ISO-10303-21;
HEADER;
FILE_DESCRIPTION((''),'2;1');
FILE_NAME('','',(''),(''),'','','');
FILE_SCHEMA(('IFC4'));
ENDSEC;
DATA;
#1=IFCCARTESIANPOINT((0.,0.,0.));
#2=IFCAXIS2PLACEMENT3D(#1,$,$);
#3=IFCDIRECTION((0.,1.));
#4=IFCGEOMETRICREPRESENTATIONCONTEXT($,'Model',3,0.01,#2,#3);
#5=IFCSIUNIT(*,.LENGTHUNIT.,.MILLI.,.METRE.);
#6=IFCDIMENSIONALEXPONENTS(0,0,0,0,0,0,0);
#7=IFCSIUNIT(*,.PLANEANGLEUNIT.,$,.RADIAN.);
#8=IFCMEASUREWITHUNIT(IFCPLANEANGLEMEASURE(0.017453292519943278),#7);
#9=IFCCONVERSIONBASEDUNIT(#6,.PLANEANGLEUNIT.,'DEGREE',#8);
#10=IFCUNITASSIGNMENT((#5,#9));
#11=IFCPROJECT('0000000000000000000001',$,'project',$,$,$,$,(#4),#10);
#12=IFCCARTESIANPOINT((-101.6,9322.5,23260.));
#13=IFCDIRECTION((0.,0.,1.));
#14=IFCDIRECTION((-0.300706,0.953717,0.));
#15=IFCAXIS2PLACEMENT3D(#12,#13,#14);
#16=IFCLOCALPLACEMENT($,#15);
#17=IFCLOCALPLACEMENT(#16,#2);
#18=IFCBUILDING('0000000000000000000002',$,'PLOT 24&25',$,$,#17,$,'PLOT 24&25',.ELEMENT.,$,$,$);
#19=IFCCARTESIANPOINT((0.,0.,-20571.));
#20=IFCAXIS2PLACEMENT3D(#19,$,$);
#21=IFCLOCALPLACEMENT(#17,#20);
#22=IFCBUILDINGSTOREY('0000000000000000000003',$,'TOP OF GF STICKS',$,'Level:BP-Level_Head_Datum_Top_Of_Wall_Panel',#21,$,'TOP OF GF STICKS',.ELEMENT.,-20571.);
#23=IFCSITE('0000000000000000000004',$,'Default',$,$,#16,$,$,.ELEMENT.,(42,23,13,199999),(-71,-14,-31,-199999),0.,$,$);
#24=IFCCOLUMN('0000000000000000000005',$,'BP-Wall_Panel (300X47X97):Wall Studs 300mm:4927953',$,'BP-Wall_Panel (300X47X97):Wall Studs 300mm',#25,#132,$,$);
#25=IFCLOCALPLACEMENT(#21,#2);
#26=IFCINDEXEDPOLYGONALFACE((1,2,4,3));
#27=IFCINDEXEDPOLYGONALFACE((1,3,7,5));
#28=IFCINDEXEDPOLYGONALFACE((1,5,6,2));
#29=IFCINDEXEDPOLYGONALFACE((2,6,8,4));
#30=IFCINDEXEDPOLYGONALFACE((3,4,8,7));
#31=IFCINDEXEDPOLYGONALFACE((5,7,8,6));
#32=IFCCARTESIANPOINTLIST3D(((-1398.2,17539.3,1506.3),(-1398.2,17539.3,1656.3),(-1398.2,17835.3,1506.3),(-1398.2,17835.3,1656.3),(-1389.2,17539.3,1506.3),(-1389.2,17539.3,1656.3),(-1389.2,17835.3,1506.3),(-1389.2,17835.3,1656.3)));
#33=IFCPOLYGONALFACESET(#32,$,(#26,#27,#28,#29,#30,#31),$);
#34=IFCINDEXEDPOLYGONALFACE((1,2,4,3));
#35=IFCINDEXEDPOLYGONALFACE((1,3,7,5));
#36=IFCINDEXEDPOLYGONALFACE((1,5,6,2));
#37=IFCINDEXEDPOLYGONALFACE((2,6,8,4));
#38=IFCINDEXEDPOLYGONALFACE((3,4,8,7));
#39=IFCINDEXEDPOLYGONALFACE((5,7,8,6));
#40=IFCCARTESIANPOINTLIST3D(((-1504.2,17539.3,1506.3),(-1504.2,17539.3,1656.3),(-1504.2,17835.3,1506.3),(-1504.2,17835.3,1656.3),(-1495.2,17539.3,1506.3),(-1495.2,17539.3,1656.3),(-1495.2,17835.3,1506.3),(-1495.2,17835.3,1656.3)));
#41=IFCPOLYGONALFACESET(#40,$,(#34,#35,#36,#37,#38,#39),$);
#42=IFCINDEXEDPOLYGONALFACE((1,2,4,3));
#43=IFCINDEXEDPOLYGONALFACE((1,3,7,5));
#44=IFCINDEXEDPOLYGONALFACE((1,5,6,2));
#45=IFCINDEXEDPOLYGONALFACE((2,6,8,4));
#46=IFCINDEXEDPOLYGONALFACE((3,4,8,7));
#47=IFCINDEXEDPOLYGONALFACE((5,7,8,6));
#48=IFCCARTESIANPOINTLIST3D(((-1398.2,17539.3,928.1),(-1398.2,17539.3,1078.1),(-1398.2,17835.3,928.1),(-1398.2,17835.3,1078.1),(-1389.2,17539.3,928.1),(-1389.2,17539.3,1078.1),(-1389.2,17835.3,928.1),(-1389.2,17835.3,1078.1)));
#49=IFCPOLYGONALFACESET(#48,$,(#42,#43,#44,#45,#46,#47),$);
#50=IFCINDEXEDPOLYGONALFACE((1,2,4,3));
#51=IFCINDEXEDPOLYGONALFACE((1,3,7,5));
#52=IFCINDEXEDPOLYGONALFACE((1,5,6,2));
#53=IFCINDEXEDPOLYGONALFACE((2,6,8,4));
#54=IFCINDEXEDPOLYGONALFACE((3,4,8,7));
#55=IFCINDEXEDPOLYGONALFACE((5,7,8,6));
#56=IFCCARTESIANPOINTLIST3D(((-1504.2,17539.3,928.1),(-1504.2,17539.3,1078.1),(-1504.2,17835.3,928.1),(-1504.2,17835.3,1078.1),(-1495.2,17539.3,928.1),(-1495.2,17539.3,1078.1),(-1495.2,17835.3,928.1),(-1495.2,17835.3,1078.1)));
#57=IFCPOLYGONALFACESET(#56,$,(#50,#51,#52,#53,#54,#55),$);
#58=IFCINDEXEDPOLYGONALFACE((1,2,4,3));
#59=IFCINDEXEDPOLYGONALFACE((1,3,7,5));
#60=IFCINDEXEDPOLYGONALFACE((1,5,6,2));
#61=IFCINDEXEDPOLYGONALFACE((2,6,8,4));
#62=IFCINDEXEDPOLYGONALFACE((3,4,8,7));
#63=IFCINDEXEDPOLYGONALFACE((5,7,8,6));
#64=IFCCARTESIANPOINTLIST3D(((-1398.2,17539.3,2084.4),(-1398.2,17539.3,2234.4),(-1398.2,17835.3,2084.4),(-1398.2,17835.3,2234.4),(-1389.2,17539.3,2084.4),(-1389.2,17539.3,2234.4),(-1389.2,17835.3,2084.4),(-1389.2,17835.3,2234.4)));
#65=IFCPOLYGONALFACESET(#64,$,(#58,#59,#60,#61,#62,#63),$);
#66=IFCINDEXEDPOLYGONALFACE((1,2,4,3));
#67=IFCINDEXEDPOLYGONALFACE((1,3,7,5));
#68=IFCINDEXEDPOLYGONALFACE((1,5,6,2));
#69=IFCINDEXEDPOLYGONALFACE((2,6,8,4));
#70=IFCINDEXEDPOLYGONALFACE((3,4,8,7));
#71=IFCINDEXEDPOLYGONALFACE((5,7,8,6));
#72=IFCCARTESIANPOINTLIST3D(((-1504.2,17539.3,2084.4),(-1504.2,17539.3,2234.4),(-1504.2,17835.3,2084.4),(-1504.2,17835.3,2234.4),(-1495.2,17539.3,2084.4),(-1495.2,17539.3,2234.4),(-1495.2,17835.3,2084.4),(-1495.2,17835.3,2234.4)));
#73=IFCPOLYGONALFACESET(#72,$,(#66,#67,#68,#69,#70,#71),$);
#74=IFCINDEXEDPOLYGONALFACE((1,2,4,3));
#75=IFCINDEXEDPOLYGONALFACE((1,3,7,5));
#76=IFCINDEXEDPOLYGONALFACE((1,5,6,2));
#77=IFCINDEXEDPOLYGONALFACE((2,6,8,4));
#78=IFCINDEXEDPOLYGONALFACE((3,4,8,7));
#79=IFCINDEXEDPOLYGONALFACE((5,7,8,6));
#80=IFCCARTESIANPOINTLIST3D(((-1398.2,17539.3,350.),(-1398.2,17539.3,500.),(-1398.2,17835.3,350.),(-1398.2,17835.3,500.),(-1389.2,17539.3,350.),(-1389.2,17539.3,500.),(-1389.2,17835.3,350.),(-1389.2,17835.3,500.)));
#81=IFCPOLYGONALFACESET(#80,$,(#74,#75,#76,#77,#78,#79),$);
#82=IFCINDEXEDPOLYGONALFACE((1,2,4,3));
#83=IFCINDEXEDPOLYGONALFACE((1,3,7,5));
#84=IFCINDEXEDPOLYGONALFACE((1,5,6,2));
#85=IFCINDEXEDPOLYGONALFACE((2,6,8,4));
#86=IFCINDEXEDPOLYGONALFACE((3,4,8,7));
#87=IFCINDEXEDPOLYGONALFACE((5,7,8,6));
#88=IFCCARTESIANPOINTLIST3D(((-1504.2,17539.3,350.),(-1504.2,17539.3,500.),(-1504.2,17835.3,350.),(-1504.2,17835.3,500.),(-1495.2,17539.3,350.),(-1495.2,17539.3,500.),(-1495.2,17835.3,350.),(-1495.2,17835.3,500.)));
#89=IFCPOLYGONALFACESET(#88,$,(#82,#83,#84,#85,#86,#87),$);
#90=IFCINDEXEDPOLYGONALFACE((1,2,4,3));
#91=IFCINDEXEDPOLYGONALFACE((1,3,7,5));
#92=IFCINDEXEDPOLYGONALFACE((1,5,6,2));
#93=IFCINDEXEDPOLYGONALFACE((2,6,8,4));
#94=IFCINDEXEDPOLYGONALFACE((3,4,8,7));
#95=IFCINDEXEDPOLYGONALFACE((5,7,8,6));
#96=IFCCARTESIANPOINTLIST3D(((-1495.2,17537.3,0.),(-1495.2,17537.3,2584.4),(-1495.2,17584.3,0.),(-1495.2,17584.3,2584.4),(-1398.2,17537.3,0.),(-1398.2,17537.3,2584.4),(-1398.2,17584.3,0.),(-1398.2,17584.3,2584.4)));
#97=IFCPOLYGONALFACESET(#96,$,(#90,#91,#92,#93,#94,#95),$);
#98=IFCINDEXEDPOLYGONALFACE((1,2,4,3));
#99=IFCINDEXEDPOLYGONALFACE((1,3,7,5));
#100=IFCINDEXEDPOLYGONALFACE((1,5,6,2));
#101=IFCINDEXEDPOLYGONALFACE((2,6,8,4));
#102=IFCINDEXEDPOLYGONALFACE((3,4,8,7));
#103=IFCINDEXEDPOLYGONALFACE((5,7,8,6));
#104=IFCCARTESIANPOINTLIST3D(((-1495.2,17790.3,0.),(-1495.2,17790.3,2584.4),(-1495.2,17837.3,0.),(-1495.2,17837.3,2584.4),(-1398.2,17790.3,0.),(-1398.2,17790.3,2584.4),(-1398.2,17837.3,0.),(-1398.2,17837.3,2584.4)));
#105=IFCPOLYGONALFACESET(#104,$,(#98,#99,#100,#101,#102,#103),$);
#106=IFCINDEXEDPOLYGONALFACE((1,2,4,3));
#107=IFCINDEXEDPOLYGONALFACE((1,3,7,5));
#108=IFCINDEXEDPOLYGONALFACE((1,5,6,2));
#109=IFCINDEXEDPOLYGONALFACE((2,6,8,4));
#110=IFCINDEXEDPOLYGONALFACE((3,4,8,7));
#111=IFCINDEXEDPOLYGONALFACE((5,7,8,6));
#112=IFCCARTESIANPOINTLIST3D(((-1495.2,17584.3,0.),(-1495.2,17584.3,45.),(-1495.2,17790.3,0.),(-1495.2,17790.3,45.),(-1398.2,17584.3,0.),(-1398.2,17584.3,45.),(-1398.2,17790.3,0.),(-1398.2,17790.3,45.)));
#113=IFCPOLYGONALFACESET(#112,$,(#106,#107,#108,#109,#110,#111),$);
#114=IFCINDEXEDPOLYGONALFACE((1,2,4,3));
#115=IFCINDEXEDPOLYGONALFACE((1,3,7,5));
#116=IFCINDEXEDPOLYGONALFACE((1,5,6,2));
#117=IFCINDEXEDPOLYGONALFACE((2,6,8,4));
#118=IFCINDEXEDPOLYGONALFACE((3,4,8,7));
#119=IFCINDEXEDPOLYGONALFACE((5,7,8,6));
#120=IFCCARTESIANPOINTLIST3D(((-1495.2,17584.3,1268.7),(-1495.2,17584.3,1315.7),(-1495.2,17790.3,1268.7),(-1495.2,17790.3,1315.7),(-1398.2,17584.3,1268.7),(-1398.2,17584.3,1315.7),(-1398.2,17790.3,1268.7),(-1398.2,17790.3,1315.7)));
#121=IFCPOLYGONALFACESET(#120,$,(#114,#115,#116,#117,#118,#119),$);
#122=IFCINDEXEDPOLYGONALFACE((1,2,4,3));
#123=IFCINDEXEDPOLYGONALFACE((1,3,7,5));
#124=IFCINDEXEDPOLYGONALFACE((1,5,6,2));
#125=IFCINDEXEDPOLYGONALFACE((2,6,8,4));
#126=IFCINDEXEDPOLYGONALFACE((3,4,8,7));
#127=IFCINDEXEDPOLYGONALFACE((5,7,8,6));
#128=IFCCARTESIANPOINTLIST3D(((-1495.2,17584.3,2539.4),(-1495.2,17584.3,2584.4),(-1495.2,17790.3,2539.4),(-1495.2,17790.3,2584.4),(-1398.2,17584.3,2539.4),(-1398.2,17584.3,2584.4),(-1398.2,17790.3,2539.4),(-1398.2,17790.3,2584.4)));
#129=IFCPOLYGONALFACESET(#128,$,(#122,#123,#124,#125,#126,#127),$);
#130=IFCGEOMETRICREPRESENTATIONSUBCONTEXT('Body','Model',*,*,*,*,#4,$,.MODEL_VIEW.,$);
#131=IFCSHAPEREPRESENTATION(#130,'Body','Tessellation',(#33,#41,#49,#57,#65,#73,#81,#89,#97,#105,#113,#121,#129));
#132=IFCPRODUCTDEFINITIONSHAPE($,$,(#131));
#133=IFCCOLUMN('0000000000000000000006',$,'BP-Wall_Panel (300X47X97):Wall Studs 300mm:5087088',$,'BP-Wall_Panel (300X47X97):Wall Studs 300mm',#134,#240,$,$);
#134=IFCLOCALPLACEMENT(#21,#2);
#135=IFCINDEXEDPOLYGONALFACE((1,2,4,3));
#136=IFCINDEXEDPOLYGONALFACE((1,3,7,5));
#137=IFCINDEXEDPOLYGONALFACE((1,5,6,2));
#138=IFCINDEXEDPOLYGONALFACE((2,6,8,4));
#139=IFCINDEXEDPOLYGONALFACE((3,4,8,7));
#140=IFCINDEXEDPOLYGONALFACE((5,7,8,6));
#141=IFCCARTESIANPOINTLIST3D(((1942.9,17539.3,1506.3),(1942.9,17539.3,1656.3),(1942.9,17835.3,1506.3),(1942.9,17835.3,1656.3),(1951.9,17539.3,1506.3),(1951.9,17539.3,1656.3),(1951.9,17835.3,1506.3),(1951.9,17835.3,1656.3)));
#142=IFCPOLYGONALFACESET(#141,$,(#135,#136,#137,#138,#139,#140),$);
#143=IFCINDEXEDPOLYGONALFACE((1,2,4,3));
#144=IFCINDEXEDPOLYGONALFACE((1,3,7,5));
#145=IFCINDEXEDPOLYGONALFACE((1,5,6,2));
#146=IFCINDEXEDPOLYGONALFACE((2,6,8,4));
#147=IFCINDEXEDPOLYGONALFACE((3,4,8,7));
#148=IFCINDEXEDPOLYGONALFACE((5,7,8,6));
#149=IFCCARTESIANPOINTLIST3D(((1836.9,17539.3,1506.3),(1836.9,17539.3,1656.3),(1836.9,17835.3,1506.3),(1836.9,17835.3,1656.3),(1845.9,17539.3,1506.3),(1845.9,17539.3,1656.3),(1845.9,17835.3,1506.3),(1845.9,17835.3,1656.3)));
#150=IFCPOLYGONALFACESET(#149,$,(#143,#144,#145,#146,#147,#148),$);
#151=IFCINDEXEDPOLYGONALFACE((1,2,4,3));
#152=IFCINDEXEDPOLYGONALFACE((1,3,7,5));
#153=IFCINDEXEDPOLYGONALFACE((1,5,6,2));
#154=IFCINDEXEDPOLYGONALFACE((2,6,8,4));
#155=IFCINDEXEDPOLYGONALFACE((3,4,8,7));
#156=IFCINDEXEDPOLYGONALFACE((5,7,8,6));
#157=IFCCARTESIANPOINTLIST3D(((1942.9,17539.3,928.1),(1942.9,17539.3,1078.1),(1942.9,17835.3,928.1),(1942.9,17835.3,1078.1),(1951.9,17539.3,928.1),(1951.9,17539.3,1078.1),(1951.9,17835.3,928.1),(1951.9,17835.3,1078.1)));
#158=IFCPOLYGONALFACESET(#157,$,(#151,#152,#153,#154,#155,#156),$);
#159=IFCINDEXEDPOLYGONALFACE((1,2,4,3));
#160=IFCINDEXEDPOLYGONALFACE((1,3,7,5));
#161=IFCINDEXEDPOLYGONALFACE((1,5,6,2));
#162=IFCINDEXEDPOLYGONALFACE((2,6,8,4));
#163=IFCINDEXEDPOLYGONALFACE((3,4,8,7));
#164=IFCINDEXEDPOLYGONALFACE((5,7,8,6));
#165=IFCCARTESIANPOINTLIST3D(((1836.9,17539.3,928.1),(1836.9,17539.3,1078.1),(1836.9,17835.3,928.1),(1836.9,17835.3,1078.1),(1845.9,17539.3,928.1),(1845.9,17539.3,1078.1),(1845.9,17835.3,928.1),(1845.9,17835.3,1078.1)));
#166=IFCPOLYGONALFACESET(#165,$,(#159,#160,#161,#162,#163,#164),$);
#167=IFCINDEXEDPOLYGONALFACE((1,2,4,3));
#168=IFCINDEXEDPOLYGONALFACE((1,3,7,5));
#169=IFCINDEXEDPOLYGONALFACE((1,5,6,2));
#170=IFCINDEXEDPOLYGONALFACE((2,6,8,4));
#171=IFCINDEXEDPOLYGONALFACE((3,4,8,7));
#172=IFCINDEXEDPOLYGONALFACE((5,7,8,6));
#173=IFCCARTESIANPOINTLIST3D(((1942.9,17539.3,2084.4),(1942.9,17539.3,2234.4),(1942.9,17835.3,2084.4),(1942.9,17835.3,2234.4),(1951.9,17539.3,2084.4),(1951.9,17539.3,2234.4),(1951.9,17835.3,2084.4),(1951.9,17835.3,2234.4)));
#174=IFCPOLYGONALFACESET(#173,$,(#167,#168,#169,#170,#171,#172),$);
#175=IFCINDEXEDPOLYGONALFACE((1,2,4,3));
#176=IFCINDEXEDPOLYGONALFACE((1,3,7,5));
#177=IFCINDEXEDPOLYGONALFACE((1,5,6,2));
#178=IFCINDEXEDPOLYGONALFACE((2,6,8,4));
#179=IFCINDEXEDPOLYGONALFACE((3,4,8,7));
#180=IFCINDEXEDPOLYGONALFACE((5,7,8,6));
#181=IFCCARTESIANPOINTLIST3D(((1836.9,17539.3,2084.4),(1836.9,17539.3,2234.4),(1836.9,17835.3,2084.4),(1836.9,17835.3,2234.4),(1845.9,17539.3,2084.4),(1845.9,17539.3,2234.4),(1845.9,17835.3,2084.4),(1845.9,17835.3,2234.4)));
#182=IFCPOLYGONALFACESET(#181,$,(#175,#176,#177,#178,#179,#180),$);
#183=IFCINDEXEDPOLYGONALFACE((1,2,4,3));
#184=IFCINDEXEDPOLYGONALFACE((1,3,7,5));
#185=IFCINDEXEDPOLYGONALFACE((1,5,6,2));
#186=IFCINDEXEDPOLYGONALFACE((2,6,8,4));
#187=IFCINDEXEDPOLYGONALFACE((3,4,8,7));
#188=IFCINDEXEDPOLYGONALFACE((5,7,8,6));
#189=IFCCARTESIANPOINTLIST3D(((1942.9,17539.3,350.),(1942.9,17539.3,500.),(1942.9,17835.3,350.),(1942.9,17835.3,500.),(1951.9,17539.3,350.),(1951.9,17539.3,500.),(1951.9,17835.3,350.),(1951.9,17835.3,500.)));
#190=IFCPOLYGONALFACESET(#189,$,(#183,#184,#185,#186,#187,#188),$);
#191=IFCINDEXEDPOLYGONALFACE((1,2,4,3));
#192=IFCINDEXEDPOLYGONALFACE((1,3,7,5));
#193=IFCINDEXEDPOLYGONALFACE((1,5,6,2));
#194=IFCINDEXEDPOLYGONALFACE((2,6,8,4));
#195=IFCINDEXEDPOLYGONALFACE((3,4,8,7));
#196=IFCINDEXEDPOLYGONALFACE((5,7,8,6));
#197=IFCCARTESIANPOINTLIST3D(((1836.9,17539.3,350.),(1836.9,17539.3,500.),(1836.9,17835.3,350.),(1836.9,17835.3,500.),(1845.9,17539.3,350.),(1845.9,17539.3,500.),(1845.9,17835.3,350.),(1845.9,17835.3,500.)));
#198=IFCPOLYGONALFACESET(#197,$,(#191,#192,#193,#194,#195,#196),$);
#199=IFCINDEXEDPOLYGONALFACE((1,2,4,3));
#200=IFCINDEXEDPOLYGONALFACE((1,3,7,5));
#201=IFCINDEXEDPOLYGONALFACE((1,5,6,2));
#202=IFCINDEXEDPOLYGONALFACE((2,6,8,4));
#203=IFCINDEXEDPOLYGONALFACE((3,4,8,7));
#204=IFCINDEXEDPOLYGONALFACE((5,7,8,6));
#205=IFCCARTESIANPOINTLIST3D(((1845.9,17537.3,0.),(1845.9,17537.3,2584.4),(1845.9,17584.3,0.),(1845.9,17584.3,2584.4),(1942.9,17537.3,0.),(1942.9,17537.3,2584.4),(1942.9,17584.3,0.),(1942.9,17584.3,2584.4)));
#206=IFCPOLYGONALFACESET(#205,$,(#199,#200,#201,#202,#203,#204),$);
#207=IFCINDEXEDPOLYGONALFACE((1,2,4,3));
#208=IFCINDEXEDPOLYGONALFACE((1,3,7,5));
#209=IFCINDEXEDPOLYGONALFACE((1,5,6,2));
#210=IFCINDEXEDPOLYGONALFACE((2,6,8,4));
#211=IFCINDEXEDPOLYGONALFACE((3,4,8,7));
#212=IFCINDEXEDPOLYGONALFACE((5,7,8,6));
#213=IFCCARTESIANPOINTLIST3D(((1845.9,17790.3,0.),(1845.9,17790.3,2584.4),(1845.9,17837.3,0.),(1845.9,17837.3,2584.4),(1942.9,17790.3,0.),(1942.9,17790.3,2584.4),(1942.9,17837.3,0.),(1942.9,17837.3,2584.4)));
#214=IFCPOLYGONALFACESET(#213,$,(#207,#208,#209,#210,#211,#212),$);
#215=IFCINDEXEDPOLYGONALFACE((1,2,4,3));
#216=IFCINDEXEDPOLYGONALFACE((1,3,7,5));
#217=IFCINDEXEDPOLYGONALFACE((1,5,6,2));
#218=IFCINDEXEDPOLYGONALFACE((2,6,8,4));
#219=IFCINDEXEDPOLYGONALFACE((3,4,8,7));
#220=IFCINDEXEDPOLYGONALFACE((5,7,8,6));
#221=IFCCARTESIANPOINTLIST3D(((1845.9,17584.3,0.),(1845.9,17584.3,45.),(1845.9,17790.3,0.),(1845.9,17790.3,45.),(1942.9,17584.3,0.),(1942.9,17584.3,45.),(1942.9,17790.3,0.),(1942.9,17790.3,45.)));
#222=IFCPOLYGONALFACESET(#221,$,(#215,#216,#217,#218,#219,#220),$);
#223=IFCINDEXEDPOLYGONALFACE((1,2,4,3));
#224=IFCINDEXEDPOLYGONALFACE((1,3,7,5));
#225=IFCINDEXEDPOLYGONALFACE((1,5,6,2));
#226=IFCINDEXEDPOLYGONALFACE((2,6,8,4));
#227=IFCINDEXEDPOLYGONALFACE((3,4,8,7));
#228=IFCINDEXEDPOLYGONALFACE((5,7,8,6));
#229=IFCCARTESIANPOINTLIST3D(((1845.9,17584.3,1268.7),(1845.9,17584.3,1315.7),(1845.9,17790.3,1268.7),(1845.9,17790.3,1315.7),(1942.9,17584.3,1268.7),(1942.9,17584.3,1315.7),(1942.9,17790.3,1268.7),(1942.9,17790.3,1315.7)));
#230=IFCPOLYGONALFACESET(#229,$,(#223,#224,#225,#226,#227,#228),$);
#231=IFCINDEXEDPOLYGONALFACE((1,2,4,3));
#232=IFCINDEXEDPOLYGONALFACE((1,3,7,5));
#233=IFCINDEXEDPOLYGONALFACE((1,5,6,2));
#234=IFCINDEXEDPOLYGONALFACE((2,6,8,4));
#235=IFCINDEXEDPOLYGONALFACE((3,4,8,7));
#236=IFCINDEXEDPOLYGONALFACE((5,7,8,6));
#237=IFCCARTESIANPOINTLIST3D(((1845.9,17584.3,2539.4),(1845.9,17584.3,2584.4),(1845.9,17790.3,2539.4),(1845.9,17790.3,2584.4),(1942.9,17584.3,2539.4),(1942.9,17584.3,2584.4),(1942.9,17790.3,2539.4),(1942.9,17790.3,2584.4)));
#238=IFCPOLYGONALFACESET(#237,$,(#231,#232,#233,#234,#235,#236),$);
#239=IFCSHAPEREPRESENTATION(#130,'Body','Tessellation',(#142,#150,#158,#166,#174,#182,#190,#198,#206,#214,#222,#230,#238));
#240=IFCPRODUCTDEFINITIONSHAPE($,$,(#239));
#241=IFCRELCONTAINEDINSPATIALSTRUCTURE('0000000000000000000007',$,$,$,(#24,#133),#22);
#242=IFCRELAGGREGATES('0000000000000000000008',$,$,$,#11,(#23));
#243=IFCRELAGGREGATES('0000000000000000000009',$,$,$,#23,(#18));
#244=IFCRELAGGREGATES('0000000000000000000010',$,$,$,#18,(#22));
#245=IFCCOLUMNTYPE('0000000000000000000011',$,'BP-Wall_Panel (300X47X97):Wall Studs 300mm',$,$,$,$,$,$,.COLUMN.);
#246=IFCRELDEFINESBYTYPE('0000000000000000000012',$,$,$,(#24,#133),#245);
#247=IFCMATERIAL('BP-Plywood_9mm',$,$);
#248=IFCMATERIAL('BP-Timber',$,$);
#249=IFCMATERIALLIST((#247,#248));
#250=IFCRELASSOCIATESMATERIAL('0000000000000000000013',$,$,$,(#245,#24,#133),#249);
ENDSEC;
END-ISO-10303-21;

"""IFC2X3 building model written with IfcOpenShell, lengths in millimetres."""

from ifc_helpers import new_model, entity, si_unit, converted_unit, direction, frame, frame_2d, origin, origin_2d_with_axis, place, context, subcontext, project, spatial, rectangle, extrude, source, transform, mapped, material, material_list, type_object, type_shapes, element, save


model = new_model("IFC2X3")

# Units and contexts
model_context = context("Model", 3, precision=0.01, world=origin(), true_north=direction((0.0, 1.0)))
body_context = subcontext(model_context, "Body", "Model", "MODEL_VIEW")
ifc_project = project(units=[si_unit("LENGTHUNIT", "METRE", prefix="MILLI"), converted_unit("PLANEANGLEUNIT", "DEGREE", entity("IfcPlaneAngleMeasure", 0.017453292519943278), si_unit("PLANEANGLEUNIT", "RADIAN"), dimensions=[0, 0, 0, 0, 0, 0, 0])], contexts=[model_context])

# Site, building, storey
site_placement = place(None, frame((-101.6, 9322.5, 23260.0), z_axis=(0.0, 0.0, 1.0), x_axis=(-0.300706, 0.953717, 0.0)))
site = spatial("IfcSite", under=ifc_project, at=site_placement, Name="Default", CompositionType="ELEMENT", RefLatitude=(42, 23, 13, 199999), RefLongitude=(-71, -14, -31, -199999), RefElevation=0.0)
building_placement = place(site_placement, origin())
building = spatial("IfcBuilding", under=site, at=building_placement, Name="PLOT 24&25", LongName="PLOT 24&25", CompositionType="ELEMENT")
storey_placement = place(building_placement, frame((0.0, 0.0, -20571.0)))
storey = spatial("IfcBuildingStorey", under=building, at=storey_placement, Name="TOP OF GF STICKS", ObjectType="Level:BP-Level_Head_Datum_Top_Of_Wall_Panel", LongName="TOP OF GF STICKS", CompositionType="ELEMENT", Elevation=-20571.0)

# Columns
ifc_material_1 = material(Name="BP-Plywood_9mm")
ifc_material_2 = material(Name="BP-Timber")
ifc_material_list = material_list([ifc_material_1, ifc_material_2])
column_type_1 = type_object("IfcColumnType", Name="BP-Wall_Panel (300X47X97):Wall Studs 300mm", PredefinedType="COLUMN", material=ifc_material_list)
shared_shape_1 = source(origin(), body_context, "Body", "SweptSolid", [
    extrude(rectangle(XDim=296.0, YDim=9.0, at=origin_2d_with_axis()), frame((53.0, 0.0, -19064.7), z_axis=(0.0, 0.0, 1.0), x_axis=(0.0, -1.0, 0.0)), (0.0, 0.0, 1.0), 150.0),
    extrude(rectangle(XDim=9.0, YDim=296.0, at=origin_2d_with_axis()), frame((-53.0, 0.0, -19064.7), z_axis=(0.0, 0.0, 1.0), x_axis=(-1.0, 0.0, 0.0)), (0.0, 0.0, 1.0), 150.0),
    extrude(rectangle(XDim=296.0, YDim=9.0, at=origin_2d_with_axis()), frame((53.0, 0.0, -19642.9), z_axis=(0.0, 0.0, 1.0), x_axis=(0.0, -1.0, 0.0)), (0.0, 0.0, 1.0), 150.0),
    extrude(rectangle(XDim=9.0, YDim=296.0, at=origin_2d_with_axis()), frame((-53.0, 0.0, -19642.9), z_axis=(0.0, 0.0, 1.0), x_axis=(-1.0, 0.0, 0.0)), (0.0, 0.0, 1.0), 150.0),
    extrude(rectangle(XDim=296.0, YDim=9.0, at=origin_2d_with_axis()), frame((53.0, 0.0, -18486.6), z_axis=(0.0, 0.0, 1.0), x_axis=(0.0, -1.0, 0.0)), (0.0, 0.0, 1.0), 150.0),
    extrude(rectangle(XDim=9.0, YDim=296.0, at=origin_2d_with_axis()), frame((-53.0, 0.0, -18486.6), z_axis=(0.0, 0.0, 1.0), x_axis=(-1.0, 0.0, 0.0)), (0.0, 0.0, 1.0), 150.0),
    extrude(rectangle(XDim=296.0, YDim=9.0, at=origin_2d_with_axis()), frame((53.0, 0.0, -20221.0), z_axis=(0.0, 0.0, 1.0), x_axis=(0.0, -1.0, 0.0)), (0.0, 0.0, 1.0), 150.0),
    extrude(rectangle(XDim=9.0, YDim=296.0, at=origin_2d_with_axis()), frame((-53.0, 0.0, -20221.0), z_axis=(0.0, 0.0, 1.0), x_axis=(-1.0, 0.0, 0.0)), (0.0, 0.0, 1.0), 150.0),
    extrude(rectangle(XDim=97.0, YDim=47.0, at=origin_2d_with_axis()), frame((0.0, -126.5, -20571.0), z_axis=(0.0, 0.0, 1.0), x_axis=(-1.0, 0.0, 0.0)), (0.0, 0.0, 1.0), 2584.4),
    extrude(rectangle(XDim=97.0, YDim=47.0, at=frame_2d((0.0, 0.0), x_axis=(1.0, 0.0))), frame((0.0, 126.5, -20571.0), z_axis=(0.0, 0.0, 1.0), x_axis=(-1.0, 0.0, 0.0)), (0.0, 0.0, 1.0), 2584.4),
    extrude(rectangle(XDim=206.0, YDim=97.0, at=origin_2d_with_axis()), frame((0.0, 0.0, -20571.0), z_axis=(0.0, 0.0, 1.0), x_axis=(0.0, -1.0, 0.0)), (0.0, 0.0, 1.0), 45.0),
    extrude(rectangle(XDim=206.0, YDim=97.0, at=origin_2d_with_axis()), frame((0.0, 0.0, -19302.3), z_axis=(0.0, 0.0, 1.0), x_axis=(0.0, -1.0, 0.0)), (0.0, 0.0, 1.0), 47.0),
    extrude(rectangle(XDim=206.0, YDim=97.0, at=origin_2d_with_axis()), frame((0.0, 0.0, -18031.6), z_axis=(0.0, 0.0, 1.0), x_axis=(0.0, -1.0, 0.0)), (0.0, 0.0, 1.0), 45.0),
])
type_shapes(column_type_1, [shared_shape_1])
for number, where, name in (
    (1, (-1446.7, 17687.3, 20571.0), "BP-Wall_Panel (300X47X97):Wall Studs 300mm:4927953"),
    (2, (1894.4, 17687.3, 20571.0), "BP-Wall_Panel (300X47X97):Wall Studs 300mm:5087088"),
):
    element("IfcColumn", number, at=place(storey_placement, frame(where)), inside=storey, type_object=column_type_1, material=ifc_material_list, Name=name, ObjectType="BP-Wall_Panel (300X47X97):Wall Studs 300mm", context=body_context, shape_type="MappedRepresentation", body=[
        mapped(shared_shape_1, transform((0.0, 0.0, 0.0), scale=1.0)),
    ])

save(model, "model.ifc")
